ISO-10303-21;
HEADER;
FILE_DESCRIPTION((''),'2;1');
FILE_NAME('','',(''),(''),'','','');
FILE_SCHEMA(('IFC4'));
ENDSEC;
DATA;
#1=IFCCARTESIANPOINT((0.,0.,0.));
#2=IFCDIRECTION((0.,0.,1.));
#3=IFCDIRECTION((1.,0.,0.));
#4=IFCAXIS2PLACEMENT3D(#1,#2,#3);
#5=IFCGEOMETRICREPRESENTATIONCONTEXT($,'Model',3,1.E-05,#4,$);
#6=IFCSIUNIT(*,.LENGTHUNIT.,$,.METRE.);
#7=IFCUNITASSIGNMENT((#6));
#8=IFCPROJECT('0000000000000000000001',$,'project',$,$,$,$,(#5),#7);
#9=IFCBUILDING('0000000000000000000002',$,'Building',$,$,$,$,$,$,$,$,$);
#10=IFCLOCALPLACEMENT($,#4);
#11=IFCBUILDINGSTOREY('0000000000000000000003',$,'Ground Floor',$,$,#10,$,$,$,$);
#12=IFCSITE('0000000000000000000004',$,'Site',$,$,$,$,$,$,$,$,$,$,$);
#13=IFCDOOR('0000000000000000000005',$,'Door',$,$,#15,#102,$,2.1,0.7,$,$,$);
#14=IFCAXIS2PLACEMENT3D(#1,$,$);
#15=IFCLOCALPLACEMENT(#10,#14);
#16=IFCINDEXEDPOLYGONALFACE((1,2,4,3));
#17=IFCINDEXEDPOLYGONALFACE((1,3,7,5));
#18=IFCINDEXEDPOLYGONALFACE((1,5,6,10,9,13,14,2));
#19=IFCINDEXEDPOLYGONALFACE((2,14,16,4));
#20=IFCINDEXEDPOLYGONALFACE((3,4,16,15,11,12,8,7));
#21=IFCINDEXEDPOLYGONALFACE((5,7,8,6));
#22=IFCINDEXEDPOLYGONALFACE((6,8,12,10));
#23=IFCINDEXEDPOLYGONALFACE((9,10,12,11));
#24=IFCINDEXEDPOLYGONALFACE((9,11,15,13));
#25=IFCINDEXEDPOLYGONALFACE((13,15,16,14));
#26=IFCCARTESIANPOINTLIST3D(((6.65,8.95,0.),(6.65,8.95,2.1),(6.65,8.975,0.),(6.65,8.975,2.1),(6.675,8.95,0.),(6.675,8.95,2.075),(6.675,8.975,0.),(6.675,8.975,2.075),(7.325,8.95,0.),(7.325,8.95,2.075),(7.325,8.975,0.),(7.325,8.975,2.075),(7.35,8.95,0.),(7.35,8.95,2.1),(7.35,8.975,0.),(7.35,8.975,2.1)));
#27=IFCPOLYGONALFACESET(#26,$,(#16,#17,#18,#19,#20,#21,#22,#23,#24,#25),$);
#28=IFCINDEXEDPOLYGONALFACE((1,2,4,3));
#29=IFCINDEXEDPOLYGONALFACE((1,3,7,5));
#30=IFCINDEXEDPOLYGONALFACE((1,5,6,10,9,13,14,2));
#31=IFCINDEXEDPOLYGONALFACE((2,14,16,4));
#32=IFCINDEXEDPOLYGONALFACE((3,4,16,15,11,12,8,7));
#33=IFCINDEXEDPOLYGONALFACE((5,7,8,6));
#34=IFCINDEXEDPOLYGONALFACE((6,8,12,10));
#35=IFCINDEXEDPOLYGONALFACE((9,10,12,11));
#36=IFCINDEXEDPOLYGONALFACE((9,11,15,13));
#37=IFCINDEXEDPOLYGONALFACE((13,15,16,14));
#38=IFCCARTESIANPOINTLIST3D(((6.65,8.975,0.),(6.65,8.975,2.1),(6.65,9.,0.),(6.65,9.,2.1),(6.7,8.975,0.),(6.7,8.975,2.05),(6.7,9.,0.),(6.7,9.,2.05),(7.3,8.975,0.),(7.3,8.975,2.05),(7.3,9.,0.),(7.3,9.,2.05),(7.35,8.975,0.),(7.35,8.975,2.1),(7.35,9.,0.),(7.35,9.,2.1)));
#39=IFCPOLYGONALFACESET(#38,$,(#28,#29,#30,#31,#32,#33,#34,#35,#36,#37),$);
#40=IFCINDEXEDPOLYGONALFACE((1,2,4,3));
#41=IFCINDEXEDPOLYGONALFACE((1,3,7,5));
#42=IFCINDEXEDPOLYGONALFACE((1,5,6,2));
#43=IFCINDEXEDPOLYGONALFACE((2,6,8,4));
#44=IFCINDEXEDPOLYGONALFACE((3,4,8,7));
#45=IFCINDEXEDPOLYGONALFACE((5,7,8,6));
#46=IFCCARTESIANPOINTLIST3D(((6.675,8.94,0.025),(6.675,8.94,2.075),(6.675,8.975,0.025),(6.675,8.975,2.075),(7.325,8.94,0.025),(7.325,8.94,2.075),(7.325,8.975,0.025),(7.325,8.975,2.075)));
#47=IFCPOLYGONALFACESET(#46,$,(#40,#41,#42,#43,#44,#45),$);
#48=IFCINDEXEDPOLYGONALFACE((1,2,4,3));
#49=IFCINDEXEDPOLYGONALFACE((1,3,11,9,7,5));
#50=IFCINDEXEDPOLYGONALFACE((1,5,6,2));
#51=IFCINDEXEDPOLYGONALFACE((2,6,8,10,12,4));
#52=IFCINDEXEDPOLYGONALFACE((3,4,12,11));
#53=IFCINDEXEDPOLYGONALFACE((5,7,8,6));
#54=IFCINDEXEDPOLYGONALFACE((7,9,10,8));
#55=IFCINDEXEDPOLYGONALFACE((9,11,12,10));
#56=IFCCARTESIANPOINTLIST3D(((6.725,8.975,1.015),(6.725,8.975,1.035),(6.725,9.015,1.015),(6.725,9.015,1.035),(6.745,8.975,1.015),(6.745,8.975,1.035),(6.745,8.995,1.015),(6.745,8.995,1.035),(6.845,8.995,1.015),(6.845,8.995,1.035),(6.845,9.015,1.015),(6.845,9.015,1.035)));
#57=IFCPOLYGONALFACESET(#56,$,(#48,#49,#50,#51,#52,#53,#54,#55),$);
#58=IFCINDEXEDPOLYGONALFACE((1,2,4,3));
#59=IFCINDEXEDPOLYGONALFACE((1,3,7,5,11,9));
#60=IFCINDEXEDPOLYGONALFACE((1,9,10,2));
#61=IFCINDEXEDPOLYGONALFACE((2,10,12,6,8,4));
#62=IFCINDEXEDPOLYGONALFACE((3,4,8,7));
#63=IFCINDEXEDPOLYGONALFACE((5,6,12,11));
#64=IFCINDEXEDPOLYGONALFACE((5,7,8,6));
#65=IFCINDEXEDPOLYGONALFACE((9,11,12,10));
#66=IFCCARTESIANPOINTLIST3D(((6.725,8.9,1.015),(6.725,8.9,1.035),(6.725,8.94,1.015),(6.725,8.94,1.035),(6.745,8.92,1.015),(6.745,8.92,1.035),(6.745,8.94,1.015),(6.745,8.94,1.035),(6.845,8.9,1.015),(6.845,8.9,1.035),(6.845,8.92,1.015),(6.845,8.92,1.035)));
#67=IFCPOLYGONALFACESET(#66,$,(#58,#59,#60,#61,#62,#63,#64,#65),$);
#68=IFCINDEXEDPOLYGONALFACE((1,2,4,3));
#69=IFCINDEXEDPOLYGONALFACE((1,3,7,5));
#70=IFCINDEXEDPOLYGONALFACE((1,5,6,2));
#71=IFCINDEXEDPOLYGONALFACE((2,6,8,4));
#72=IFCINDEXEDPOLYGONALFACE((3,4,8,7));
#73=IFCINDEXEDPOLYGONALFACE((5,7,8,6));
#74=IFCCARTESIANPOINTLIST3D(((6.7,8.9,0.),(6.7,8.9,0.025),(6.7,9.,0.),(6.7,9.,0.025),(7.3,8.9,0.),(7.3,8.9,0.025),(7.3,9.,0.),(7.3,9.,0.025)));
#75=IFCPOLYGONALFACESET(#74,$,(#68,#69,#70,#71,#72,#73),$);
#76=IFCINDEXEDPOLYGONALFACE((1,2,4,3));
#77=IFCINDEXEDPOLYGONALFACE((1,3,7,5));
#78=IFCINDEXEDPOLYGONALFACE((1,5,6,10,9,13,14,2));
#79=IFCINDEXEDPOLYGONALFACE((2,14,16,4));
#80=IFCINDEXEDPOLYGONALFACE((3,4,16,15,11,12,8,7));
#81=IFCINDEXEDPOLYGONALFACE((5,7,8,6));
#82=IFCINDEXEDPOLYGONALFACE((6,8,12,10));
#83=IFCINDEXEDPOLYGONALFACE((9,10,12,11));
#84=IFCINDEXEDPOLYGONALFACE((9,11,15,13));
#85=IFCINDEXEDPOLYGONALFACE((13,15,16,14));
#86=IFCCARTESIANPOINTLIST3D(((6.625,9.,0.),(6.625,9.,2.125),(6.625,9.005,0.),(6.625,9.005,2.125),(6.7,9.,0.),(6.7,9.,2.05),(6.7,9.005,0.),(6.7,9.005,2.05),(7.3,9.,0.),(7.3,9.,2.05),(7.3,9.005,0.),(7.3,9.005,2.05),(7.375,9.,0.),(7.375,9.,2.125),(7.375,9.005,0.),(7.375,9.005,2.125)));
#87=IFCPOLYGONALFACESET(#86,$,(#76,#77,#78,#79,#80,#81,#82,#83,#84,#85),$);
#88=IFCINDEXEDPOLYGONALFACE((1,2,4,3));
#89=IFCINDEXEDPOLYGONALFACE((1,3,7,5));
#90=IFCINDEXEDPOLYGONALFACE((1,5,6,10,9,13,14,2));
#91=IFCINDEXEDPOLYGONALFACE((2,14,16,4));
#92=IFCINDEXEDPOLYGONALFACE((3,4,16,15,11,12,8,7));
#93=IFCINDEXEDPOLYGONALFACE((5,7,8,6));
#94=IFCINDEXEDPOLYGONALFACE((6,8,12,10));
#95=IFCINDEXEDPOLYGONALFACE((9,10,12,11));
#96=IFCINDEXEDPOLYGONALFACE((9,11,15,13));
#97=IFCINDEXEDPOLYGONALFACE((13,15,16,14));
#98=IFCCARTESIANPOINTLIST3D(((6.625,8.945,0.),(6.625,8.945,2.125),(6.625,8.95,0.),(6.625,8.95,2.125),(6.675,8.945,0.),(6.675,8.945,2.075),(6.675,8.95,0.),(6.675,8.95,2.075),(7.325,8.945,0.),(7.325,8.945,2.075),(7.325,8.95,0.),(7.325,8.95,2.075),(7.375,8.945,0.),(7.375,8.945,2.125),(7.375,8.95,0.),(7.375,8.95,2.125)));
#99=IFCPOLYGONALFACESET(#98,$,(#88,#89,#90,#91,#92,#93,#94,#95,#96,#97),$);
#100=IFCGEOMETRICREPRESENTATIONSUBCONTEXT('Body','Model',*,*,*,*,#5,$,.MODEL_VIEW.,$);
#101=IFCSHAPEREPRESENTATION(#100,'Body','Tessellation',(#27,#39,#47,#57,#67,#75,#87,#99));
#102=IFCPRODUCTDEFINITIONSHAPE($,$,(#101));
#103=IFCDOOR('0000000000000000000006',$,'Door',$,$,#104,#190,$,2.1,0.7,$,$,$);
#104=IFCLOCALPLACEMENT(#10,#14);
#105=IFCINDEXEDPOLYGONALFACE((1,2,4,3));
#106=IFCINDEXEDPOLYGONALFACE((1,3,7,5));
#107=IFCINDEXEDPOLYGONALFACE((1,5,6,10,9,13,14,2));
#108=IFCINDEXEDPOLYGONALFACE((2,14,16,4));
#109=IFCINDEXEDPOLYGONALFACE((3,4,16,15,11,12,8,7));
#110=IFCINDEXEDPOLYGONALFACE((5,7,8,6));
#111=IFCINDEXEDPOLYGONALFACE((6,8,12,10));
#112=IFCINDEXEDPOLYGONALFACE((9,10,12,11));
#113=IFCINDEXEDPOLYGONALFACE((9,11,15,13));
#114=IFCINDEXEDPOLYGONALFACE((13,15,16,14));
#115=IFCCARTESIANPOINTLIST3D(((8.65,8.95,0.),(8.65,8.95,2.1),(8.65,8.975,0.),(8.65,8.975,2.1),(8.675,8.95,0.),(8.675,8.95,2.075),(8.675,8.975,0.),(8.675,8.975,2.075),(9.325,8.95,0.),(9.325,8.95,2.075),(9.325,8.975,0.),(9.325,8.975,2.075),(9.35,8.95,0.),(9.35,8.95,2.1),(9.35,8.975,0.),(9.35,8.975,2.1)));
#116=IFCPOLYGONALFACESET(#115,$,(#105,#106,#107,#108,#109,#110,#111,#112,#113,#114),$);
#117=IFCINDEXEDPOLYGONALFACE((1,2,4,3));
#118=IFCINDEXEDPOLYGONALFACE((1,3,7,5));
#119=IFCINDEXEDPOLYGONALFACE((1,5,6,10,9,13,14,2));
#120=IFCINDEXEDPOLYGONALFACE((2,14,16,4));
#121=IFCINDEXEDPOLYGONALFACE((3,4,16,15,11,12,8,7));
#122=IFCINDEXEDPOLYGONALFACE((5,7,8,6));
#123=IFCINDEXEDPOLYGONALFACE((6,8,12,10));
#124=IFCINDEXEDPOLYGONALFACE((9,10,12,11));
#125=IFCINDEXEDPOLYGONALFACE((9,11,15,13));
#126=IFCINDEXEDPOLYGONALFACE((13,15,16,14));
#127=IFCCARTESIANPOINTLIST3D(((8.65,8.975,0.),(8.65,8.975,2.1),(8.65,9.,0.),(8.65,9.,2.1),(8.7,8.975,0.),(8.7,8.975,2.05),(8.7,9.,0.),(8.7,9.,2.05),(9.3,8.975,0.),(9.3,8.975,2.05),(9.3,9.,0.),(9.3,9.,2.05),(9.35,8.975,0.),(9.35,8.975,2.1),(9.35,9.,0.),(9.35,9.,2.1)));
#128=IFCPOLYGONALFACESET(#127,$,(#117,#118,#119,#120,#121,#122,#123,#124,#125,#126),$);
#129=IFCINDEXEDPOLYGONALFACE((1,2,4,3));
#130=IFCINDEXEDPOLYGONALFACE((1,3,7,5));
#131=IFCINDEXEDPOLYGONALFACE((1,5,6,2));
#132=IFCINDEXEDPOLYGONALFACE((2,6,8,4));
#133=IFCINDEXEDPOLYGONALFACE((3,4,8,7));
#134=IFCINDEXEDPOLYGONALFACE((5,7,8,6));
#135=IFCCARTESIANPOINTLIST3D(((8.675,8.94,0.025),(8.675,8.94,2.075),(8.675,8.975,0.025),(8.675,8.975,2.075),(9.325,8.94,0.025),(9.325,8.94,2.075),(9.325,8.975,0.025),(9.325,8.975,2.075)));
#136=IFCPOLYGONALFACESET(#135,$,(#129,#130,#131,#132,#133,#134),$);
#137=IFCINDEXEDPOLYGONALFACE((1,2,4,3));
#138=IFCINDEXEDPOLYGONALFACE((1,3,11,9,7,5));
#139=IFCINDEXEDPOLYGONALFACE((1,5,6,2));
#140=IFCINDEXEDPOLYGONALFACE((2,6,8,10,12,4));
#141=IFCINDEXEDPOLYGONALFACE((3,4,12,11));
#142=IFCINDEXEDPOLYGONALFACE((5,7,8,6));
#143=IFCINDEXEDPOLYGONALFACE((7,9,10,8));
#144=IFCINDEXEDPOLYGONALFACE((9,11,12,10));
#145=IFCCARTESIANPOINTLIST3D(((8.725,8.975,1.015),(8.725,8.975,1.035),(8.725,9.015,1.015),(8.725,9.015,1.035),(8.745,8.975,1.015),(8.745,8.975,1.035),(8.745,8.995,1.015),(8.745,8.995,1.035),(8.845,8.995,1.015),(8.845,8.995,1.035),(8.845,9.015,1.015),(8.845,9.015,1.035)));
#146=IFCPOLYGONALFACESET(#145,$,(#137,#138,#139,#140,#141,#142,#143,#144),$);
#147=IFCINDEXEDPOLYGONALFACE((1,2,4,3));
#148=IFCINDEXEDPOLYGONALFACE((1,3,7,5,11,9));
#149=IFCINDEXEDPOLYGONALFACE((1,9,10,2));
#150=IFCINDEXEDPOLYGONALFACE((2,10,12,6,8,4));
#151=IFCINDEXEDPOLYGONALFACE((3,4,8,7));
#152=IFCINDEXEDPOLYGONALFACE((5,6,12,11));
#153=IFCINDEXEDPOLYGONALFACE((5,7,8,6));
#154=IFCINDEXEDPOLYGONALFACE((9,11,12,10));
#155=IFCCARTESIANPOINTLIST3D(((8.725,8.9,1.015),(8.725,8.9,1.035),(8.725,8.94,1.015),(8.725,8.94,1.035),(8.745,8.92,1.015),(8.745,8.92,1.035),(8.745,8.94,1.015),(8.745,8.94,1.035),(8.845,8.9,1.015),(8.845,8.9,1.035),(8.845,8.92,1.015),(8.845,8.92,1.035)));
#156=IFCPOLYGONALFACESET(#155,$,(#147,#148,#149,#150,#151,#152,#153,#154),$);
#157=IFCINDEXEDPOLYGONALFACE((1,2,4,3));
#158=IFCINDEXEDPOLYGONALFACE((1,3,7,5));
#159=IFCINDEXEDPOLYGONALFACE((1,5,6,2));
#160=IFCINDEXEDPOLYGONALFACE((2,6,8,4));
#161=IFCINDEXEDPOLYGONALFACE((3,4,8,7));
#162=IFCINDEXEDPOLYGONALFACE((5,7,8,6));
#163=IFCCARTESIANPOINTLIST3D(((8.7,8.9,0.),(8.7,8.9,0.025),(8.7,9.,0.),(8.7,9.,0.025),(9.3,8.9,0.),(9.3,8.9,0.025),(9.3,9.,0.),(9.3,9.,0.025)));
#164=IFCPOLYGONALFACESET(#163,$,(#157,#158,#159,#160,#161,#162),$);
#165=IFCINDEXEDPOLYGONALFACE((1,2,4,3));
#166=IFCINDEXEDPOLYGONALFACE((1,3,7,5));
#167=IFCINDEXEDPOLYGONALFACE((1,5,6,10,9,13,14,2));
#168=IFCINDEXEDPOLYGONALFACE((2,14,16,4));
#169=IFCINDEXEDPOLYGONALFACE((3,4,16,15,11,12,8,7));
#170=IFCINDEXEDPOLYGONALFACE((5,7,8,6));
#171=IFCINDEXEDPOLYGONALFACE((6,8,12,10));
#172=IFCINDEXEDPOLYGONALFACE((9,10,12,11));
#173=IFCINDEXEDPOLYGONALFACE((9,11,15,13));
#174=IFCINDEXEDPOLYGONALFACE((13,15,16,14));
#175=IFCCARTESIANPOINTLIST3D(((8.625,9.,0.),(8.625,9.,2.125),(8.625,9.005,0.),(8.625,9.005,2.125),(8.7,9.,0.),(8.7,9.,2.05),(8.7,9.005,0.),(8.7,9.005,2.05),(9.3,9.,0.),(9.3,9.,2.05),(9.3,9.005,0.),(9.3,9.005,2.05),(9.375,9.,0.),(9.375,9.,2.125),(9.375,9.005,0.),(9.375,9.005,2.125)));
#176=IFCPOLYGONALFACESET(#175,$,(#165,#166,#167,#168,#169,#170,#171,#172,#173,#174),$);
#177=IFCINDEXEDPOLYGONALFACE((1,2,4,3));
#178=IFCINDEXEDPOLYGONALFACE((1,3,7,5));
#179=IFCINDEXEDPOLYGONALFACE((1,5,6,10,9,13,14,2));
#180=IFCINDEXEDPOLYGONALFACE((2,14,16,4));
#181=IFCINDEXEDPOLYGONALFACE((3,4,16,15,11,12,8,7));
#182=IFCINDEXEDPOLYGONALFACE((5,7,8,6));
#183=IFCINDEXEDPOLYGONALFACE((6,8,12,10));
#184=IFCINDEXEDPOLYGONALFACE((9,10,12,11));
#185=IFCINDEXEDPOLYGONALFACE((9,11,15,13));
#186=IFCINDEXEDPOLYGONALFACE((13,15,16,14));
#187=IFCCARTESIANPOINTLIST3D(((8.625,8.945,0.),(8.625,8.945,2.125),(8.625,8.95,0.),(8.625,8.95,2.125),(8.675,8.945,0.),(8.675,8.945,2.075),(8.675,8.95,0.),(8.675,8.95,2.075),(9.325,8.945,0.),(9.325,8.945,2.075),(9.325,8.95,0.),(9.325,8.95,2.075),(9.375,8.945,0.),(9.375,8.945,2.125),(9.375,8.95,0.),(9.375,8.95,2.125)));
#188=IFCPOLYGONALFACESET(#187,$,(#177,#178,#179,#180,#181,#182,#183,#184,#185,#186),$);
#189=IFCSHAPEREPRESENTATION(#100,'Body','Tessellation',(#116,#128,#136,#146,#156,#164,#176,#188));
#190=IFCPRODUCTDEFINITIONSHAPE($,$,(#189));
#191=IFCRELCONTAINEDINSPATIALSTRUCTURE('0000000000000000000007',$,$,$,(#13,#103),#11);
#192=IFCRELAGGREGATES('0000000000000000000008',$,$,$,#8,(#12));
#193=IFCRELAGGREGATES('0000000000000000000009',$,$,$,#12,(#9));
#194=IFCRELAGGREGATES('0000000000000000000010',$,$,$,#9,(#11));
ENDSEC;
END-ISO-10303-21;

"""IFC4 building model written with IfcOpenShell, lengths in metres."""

from ifc_helpers import new_model, si_unit, frame, origin_with_axes, place, context, subcontext, project, spatial, line, indexed_curve, outline, extrude, element, save


model = new_model("IFC4")

# Units and contexts
model_context = context("Model", 3, precision=1e-05, world=origin_with_axes())
body_context = subcontext(model_context, "Body", "Model", "MODEL_VIEW")
ifc_project = project(units=[si_unit("LENGTHUNIT", "METRE")], contexts=[model_context])

# Site, building, storey
site = spatial("IfcSite", under=ifc_project, Name="Site")
building = spatial("IfcBuilding", under=site, Name="Building")
storey_placement = place(None, origin_with_axes())
storey = spatial("IfcBuildingStorey", under=building, at=storey_placement, Name="Ground Floor")

# Doors
door_1_placement = place(storey_placement, frame((7.35, 9.0, 0.0), z_axis=(0.0, 0.0, 1.0), x_axis=(-1.0, 0.0, 0.0)))
element("IfcDoor", 1, at=door_1_placement, inside=storey, Name="Door", OverallHeight=2.1, OverallWidth=0.7, context=body_context, shape_type="SweptSolid", body=[
    extrude(outline(indexed_curve([(0.0, 0.0), (0.0, 2.1), (0.7, 2.1), (0.7, 0.0), (0.675, 0.0), (0.675, 2.075), (0.025, 2.075), (0.025, 0.0)], segments=[line(1, 2, 3, 4, 5, 6, 7, 8, 1)])), frame((0.0, 0.025, 0.0), z_axis=(0.0, -1.0, 0.0), x_axis=(1.0, 0.0, 0.0)), (0.0, 0.0, -1.0), 0.025),
    extrude(outline(indexed_curve([(0.0, 0.0), (0.0, 2.1), (0.7, 2.1), (0.7, 0.0), (0.65, 0.0), (0.65, 2.05), (0.05, 2.05), (0.05, 0.0)], segments=[line(1, 2, 3, 4, 5, 6, 7, 8, 1)])), frame((0.0, 0.0, 0.0), z_axis=(0.0, -1.0, 0.0), x_axis=(1.0, 0.0, 0.0)), (0.0, 0.0, -1.0), 0.025),
    extrude(outline(indexed_curve([(0.0, 0.0), (0.65, 0.0), (0.65, 0.035), (0.0, 0.035)], segments=[line(1, 2, 3, 4, 1)])), frame((0.025, 0.025, 0.025), z_axis=(0.0, 0.0, 1.0), x_axis=(1.0, 0.0, 0.0)), (0.0, 0.0, 1.0), 2.05),
    extrude(outline(indexed_curve([(0.0, 0.0), (0.0, -0.04), (-0.12, -0.04), (-0.12, -0.02), (-0.02, -0.02), (-0.02, 0.0)], segments=[line(1, 2, 3, 4, 5, 6, 1)])), frame((0.625, 0.025, 1.015), z_axis=(0.0, 0.0, 1.0), x_axis=(1.0, 0.0, 0.0)), (0.0, 0.0, 1.0), 0.02),
    extrude(outline(indexed_curve([(0.0, 0.0), (0.0, 0.04), (-0.12, 0.04), (-0.12, 0.02), (-0.02, 0.02), (-0.02, 0.0)], segments=[line(1, 2, 3, 4, 5, 6, 1)])), frame((0.625, 0.06, 1.015), z_axis=(0.0, 0.0, 1.0), x_axis=(1.0, 0.0, 0.0)), (0.0, 0.0, 1.0), 0.02),
    extrude(outline(indexed_curve([(0.0, 0.0), (0.6, 0.0), (0.6, 0.1), (0.0, 0.1)], segments=[line(1, 2, 3, 4, 1)])), frame((0.05, 0.0, 0.0), z_axis=(0.0, 0.0, 1.0), x_axis=(1.0, 0.0, 0.0)), (0.0, 0.0, 1.0), 0.025),
    extrude(outline(indexed_curve([(0.0, 0.0), (0.0, 2.125), (0.75, 2.125), (0.75, 0.0), (0.675, 0.0), (0.675, 2.05), (0.075, 2.05), (0.075, 0.0)], segments=[line(1, 2, 3, 4, 5, 6, 7, 8, 1)])), frame((-0.025, -0.005, 0.0), z_axis=(0.0, -1.0, 0.0), x_axis=(1.0, 0.0, 0.0)), (0.0, 0.0, -1.0), 0.005),
    extrude(outline(indexed_curve([(0.0, 0.0), (0.0, 2.125), (0.75, 2.125), (0.75, 0.0), (0.7, 0.0), (0.7, 2.075), (0.05, 2.075), (0.05, 0.0)], segments=[line(1, 2, 3, 4, 5, 6, 7, 8, 1)])), frame((-0.025, 0.05, 0.0), z_axis=(0.0, -1.0, 0.0), x_axis=(1.0, 0.0, 0.0)), (0.0, 0.0, -1.0), 0.005),
])
door_2_placement = place(storey_placement, frame((9.35, 9.0, 0.0), z_axis=(0.0, 0.0, 1.0), x_axis=(-1.0, 0.0, 0.0)))
element("IfcDoor", 2, at=door_2_placement, inside=storey, Name="Door", OverallHeight=2.1, OverallWidth=0.7, context=body_context, shape_type="SweptSolid", body=[
    extrude(outline(indexed_curve([(0.0, 0.0), (0.0, 2.1), (0.7, 2.1), (0.7, 0.0), (0.675, 0.0), (0.675, 2.075), (0.025, 2.075), (0.025, 0.0)], segments=[line(1, 2, 3, 4, 5, 6, 7, 8, 1)])), frame((0.0, 0.025, 0.0), z_axis=(0.0, -1.0, 0.0), x_axis=(1.0, 0.0, 0.0)), (0.0, 0.0, -1.0), 0.025),
    extrude(outline(indexed_curve([(0.0, 0.0), (0.0, 2.1), (0.7, 2.1), (0.7, 0.0), (0.65, 0.0), (0.65, 2.05), (0.05, 2.05), (0.05, 0.0)], segments=[line(1, 2, 3, 4, 5, 6, 7, 8, 1)])), frame((0.0, 0.0, 0.0), z_axis=(0.0, -1.0, 0.0), x_axis=(1.0, 0.0, 0.0)), (0.0, 0.0, -1.0), 0.025),
    extrude(outline(indexed_curve([(0.0, 0.0), (0.65, 0.0), (0.65, 0.035), (0.0, 0.035)], segments=[line(1, 2, 3, 4, 1)])), frame((0.025, 0.025, 0.025), z_axis=(0.0, 0.0, 1.0), x_axis=(1.0, 0.0, 0.0)), (0.0, 0.0, 1.0), 2.05),
    extrude(outline(indexed_curve([(0.0, 0.0), (0.0, -0.04), (-0.12, -0.04), (-0.12, -0.02), (-0.02, -0.02), (-0.02, 0.0)], segments=[line(1, 2, 3, 4, 5, 6, 1)])), frame((0.625, 0.025, 1.015), z_axis=(0.0, 0.0, 1.0), x_axis=(1.0, 0.0, 0.0)), (0.0, 0.0, 1.0), 0.02),
    extrude(outline(indexed_curve([(0.0, 0.0), (0.0, 0.04), (-0.12, 0.04), (-0.12, 0.02), (-0.02, 0.02), (-0.02, 0.0)], segments=[line(1, 2, 3, 4, 5, 6, 1)])), frame((0.625, 0.06, 1.015), z_axis=(0.0, 0.0, 1.0), x_axis=(1.0, 0.0, 0.0)), (0.0, 0.0, 1.0), 0.02),
    extrude(outline(indexed_curve([(0.0, 0.0), (0.6, 0.0), (0.6, 0.1), (0.0, 0.1)], segments=[line(1, 2, 3, 4, 1)])), frame((0.05, 0.0, 0.0), z_axis=(0.0, 0.0, 1.0), x_axis=(1.0, 0.0, 0.0)), (0.0, 0.0, 1.0), 0.025),
    extrude(outline(indexed_curve([(0.0, 0.0), (0.0, 2.125), (0.75, 2.125), (0.75, 0.0), (0.675, 0.0), (0.675, 2.05), (0.075, 2.05), (0.075, 0.0)], segments=[line(1, 2, 3, 4, 5, 6, 7, 8, 1)])), frame((-0.025, -0.005, 0.0), z_axis=(0.0, -1.0, 0.0), x_axis=(1.0, 0.0, 0.0)), (0.0, 0.0, -1.0), 0.005),
    extrude(outline(indexed_curve([(0.0, 0.0), (0.0, 2.125), (0.75, 2.125), (0.75, 0.0), (0.7, 0.0), (0.7, 2.075), (0.05, 2.075), (0.05, 0.0)], segments=[line(1, 2, 3, 4, 5, 6, 7, 8, 1)])), frame((-0.025, 0.05, 0.0), z_axis=(0.0, -1.0, 0.0), x_axis=(1.0, 0.0, 0.0)), (0.0, 0.0, -1.0), 0.005),
])

save(model, "model.ifc")
